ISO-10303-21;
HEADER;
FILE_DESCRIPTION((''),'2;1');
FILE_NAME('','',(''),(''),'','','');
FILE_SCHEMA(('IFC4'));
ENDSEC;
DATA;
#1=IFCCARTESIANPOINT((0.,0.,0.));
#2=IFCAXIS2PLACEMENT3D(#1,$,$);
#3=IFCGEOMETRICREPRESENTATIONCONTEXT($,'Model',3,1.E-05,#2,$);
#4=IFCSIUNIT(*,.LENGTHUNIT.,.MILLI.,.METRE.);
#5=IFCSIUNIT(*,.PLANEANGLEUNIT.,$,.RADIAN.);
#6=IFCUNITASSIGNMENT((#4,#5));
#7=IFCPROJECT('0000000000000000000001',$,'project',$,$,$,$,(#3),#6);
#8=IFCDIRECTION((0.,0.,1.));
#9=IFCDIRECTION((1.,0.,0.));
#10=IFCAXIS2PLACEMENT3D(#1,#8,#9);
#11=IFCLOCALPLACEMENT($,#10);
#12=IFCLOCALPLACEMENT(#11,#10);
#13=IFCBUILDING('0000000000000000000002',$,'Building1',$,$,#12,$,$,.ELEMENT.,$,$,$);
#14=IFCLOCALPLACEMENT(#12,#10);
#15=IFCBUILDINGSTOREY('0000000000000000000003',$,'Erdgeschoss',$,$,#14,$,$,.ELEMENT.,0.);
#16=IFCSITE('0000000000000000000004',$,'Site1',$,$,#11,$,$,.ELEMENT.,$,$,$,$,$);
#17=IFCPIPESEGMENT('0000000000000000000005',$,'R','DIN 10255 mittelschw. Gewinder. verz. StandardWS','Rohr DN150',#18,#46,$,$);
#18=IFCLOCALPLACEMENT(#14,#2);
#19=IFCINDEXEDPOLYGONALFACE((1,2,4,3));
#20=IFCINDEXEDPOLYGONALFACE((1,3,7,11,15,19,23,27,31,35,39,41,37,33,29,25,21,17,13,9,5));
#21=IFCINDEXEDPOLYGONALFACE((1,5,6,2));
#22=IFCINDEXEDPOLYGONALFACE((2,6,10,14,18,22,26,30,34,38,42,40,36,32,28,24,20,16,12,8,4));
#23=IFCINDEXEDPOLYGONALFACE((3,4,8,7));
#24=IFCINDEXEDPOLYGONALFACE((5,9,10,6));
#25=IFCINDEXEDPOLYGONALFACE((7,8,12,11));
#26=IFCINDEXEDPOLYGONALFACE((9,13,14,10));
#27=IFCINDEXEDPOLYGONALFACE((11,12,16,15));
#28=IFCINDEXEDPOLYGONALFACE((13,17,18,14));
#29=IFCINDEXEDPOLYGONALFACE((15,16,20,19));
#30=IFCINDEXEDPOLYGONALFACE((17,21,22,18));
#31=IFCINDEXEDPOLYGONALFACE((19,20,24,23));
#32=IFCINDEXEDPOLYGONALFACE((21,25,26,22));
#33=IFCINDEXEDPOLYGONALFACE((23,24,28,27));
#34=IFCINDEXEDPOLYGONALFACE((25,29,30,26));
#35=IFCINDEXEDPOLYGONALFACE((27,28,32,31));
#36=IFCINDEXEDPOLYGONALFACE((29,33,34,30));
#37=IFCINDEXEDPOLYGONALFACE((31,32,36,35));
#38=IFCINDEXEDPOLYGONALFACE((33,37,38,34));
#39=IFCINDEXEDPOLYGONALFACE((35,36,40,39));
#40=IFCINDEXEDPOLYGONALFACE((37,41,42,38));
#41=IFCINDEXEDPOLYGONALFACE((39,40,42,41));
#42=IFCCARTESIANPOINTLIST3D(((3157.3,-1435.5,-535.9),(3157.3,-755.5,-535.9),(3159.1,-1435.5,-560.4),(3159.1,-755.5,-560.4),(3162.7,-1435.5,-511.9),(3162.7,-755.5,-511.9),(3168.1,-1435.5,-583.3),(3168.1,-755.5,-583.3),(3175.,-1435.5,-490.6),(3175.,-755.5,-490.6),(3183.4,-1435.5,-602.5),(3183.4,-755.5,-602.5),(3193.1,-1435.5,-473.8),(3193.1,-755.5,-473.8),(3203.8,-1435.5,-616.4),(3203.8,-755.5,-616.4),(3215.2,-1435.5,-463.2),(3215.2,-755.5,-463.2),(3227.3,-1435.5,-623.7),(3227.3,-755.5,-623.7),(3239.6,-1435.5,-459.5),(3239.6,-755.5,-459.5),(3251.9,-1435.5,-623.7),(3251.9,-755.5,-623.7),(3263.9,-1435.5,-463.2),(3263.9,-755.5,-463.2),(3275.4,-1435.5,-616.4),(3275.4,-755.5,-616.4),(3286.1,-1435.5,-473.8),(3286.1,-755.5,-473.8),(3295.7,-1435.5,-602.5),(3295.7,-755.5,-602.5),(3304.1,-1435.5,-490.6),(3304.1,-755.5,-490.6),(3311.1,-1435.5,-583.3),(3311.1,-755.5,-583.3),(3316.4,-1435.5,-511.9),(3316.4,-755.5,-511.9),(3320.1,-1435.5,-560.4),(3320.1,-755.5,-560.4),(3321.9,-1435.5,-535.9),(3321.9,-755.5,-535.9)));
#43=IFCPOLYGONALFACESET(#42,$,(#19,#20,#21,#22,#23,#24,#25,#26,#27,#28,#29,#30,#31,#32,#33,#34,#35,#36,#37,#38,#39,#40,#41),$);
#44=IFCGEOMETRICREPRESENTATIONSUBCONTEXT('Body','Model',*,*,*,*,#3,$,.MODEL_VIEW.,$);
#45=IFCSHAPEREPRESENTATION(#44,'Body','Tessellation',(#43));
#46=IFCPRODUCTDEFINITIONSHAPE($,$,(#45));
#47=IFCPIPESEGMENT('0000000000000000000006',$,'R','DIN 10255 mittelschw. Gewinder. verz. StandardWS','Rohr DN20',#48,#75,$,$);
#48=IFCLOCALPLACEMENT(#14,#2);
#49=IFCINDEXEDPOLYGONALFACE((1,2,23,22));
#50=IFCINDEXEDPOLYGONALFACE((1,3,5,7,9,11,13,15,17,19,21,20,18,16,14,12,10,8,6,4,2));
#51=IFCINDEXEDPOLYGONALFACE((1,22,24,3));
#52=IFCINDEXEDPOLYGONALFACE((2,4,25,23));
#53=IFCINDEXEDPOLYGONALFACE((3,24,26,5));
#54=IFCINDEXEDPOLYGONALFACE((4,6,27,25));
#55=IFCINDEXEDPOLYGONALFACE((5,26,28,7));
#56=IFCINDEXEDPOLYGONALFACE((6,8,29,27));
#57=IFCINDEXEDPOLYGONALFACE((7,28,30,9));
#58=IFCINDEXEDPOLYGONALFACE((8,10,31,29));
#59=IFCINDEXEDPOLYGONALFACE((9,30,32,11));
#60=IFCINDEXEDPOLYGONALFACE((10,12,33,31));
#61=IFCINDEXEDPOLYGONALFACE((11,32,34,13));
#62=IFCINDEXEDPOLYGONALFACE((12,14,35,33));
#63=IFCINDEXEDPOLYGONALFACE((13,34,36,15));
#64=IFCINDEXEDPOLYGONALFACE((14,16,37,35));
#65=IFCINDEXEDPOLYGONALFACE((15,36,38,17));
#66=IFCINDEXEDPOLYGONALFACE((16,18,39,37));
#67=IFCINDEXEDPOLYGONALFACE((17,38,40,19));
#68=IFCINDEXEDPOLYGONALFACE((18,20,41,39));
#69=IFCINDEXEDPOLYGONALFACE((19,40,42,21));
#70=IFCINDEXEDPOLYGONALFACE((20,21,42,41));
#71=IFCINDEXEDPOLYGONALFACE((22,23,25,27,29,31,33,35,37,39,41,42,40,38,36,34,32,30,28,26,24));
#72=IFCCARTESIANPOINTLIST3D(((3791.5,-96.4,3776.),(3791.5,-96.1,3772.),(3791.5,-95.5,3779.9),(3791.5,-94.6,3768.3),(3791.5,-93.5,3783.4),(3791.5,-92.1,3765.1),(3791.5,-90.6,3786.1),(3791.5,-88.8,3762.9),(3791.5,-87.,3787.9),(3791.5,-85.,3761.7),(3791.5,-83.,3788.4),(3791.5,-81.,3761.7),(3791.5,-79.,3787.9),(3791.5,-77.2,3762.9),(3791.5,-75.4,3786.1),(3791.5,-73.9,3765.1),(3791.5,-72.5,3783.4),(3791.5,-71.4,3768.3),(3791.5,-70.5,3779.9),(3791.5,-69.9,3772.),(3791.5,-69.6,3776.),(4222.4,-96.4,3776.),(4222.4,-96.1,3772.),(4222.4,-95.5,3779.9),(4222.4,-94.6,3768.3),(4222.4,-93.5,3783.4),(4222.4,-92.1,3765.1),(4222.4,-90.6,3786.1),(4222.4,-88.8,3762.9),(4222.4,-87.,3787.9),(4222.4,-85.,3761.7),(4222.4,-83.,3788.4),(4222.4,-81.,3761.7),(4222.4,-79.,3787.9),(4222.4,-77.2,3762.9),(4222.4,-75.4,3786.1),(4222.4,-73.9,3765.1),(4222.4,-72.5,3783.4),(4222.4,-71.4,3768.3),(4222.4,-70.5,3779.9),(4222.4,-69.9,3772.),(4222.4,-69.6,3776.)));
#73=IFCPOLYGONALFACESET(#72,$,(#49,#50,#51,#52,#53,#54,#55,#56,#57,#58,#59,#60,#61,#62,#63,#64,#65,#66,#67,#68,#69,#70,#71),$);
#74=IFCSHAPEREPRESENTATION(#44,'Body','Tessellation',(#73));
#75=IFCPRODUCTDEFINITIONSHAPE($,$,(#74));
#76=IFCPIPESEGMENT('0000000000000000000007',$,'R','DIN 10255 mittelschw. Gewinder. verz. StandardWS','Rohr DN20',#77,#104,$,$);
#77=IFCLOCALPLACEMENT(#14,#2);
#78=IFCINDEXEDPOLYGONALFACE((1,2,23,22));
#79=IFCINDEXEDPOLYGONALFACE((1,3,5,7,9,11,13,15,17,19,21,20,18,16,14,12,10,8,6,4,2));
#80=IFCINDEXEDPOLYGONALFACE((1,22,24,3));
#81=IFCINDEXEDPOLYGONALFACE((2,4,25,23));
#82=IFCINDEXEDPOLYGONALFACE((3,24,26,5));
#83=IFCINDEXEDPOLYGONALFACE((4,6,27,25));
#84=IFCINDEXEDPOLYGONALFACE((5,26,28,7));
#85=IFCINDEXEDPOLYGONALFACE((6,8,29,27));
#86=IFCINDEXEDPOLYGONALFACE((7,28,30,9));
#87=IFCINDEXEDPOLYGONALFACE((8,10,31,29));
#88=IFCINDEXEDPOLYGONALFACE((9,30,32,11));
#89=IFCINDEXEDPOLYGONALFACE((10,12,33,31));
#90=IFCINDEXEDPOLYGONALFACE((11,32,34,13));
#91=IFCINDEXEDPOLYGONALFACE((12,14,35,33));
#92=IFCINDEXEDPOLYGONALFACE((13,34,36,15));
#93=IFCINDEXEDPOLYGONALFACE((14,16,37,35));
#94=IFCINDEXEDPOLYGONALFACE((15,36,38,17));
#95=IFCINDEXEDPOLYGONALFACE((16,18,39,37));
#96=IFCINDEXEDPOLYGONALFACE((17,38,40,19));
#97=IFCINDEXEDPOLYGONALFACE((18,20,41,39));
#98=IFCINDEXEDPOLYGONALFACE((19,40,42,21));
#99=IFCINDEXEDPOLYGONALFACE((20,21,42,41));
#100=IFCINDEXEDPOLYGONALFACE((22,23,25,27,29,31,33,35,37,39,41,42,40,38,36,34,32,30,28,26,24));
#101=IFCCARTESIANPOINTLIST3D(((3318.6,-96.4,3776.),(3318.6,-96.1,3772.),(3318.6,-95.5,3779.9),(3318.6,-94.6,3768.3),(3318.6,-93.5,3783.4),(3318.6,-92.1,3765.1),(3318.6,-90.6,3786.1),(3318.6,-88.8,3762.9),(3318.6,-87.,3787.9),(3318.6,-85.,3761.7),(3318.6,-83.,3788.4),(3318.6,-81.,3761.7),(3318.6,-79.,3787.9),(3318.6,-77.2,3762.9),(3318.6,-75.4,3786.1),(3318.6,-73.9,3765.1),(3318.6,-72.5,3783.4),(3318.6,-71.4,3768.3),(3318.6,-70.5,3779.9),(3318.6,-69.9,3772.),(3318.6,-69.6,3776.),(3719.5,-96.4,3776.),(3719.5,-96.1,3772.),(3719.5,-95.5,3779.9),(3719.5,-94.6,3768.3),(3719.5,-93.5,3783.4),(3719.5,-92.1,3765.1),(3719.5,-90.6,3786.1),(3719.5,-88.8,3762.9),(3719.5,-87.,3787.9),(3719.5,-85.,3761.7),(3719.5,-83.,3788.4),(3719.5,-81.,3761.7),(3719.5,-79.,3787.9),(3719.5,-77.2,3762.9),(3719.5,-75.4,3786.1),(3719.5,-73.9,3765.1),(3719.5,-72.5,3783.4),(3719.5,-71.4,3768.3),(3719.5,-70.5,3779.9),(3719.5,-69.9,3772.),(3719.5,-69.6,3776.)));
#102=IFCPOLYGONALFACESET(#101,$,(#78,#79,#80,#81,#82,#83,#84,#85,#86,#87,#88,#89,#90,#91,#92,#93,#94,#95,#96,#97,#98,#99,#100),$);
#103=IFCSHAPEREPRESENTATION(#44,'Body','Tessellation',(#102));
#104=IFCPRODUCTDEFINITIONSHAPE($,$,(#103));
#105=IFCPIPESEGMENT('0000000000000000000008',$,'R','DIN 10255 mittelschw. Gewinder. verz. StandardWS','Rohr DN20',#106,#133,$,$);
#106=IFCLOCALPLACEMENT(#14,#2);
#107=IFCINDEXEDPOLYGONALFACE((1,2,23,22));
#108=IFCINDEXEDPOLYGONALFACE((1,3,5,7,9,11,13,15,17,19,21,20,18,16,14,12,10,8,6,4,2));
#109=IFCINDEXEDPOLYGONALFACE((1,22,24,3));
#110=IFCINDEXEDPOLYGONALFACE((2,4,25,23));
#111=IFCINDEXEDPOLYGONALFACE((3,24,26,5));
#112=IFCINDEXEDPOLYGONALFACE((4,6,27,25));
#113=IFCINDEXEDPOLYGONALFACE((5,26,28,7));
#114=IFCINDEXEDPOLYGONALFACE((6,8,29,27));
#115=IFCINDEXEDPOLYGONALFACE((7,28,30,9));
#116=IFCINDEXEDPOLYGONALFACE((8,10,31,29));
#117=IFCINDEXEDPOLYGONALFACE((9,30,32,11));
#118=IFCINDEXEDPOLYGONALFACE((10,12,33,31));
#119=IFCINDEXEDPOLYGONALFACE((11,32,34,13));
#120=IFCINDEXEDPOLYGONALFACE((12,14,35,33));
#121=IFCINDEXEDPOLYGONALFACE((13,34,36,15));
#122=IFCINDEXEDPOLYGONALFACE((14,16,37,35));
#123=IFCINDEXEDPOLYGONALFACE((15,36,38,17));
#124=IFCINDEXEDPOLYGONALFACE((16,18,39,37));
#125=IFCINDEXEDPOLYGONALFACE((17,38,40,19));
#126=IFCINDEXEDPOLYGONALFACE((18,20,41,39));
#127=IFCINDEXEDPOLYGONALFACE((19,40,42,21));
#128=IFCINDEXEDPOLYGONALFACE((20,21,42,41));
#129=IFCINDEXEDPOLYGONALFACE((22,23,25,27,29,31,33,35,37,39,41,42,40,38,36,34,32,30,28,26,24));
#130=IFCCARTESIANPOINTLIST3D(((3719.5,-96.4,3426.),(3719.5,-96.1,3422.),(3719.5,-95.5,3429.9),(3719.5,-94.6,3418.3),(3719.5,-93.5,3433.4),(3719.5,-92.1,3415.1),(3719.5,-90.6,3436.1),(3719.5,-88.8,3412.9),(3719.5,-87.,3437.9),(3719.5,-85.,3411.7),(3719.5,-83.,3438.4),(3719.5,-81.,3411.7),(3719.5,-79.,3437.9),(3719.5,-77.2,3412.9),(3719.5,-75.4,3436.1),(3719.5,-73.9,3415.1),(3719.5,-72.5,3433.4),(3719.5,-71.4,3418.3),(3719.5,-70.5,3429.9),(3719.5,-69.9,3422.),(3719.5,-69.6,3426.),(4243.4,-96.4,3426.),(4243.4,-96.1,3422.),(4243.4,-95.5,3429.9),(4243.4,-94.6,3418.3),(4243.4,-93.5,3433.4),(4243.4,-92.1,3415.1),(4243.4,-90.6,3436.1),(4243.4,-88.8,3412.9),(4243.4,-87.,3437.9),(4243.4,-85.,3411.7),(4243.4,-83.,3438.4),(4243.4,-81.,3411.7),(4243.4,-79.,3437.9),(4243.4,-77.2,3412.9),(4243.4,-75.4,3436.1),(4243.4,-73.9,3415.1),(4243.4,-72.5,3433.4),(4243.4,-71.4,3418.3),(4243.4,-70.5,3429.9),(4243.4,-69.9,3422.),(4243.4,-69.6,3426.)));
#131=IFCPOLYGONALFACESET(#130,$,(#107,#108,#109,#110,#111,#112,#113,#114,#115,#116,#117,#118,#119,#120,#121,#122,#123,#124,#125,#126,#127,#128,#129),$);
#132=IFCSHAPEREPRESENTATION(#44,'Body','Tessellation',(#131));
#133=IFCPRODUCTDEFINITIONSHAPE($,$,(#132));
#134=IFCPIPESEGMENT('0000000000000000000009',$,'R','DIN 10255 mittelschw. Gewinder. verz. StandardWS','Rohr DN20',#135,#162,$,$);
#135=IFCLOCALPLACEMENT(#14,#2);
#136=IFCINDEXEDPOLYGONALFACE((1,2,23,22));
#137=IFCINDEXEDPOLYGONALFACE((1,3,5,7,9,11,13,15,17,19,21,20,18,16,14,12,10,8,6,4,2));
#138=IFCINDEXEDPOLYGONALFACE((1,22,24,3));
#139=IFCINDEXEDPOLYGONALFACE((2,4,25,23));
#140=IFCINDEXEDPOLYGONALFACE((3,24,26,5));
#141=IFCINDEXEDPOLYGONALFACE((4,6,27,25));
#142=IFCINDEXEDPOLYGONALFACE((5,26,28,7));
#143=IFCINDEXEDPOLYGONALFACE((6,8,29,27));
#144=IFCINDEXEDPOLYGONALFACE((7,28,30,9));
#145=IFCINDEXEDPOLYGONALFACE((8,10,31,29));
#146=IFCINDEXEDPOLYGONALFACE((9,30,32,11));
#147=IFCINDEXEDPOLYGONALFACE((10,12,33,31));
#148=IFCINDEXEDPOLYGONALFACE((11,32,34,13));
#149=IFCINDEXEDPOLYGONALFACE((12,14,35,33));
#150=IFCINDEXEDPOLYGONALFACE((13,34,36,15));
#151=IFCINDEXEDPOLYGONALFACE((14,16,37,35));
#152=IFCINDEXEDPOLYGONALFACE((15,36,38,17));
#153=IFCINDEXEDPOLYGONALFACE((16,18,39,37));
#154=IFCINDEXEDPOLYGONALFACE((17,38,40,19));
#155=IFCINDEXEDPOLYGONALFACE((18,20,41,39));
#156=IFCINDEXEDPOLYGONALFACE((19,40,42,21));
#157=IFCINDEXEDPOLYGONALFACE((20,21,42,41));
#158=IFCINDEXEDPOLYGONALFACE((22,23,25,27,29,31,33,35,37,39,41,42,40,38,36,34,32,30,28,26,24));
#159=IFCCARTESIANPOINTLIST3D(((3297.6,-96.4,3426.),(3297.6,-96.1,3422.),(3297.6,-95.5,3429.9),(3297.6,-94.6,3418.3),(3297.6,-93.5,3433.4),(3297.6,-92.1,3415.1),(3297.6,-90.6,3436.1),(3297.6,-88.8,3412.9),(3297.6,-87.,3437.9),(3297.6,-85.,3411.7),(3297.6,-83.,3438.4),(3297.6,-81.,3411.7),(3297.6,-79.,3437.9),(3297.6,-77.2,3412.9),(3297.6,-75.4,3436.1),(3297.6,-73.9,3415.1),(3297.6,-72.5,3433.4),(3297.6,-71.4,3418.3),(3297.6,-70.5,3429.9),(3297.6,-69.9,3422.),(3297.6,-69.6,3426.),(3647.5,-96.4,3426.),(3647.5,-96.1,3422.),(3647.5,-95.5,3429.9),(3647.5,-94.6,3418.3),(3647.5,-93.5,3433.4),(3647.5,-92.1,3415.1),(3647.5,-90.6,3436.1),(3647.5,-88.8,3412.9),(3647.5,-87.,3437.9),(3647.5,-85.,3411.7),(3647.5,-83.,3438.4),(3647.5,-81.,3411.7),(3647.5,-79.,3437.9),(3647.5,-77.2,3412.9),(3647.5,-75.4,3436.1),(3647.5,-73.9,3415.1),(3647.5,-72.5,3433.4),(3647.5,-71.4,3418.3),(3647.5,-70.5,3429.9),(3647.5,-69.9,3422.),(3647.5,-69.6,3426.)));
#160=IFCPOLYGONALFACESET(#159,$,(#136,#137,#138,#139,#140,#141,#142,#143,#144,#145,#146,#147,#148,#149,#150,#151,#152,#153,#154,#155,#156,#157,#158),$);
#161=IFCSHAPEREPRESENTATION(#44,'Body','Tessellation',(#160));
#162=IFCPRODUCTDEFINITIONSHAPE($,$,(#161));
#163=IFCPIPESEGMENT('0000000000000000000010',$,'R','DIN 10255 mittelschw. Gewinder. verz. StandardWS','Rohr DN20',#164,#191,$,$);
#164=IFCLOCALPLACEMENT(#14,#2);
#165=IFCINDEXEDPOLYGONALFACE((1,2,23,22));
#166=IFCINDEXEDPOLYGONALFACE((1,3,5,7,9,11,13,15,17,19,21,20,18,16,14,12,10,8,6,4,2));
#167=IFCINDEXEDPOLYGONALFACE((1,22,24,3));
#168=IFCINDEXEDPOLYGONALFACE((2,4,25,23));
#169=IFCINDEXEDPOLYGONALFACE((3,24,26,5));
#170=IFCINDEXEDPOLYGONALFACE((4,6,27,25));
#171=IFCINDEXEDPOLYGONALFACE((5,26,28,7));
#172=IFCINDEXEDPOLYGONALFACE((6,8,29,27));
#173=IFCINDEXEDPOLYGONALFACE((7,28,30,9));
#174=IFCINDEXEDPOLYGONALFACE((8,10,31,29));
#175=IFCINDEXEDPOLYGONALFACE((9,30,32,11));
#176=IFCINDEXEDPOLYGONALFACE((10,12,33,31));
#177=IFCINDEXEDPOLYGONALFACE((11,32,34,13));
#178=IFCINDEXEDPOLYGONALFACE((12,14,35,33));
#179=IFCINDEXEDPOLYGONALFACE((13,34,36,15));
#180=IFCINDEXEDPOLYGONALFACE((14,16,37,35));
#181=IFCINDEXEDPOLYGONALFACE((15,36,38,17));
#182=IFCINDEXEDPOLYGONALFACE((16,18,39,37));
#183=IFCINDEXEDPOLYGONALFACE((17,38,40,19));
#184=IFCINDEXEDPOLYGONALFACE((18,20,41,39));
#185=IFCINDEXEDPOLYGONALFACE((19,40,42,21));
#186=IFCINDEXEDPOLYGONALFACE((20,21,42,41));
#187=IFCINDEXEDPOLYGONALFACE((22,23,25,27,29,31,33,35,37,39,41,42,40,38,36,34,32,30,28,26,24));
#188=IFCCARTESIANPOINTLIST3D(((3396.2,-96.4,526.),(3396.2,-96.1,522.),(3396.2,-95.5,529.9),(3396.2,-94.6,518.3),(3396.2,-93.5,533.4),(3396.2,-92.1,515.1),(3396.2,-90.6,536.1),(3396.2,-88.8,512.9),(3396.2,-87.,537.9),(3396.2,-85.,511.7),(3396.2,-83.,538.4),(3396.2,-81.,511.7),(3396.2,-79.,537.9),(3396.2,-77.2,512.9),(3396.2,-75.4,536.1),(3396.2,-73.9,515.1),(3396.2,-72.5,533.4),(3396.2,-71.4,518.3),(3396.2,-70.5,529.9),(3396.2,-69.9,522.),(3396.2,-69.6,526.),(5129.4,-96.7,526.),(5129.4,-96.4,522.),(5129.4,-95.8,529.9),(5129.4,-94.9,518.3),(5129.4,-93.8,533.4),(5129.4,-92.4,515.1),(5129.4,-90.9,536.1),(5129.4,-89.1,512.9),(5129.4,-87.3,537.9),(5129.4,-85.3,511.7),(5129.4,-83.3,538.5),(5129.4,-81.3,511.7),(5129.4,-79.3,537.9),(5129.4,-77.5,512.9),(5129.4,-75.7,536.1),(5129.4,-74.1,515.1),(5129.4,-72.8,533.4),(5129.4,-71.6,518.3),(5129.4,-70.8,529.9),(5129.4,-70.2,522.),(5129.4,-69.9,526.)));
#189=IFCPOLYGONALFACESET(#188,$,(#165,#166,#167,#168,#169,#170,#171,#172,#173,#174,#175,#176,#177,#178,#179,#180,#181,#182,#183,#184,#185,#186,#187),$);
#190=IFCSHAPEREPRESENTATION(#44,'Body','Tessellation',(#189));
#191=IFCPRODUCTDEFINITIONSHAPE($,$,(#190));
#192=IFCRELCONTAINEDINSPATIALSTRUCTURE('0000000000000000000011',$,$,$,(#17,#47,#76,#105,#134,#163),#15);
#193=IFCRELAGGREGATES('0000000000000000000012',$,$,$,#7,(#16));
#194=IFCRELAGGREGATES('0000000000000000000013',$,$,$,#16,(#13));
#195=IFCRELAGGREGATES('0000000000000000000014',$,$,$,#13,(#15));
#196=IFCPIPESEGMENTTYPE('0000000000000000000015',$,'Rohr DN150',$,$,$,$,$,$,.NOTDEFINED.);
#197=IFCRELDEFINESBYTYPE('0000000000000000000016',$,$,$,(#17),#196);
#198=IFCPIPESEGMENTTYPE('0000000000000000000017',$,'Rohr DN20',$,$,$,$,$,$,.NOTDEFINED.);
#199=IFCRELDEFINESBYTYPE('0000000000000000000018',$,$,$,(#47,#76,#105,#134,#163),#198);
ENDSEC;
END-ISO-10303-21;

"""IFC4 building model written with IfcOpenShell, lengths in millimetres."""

from ifc_helpers import new_model, si_unit, frame, origin, origin_with_axes, origin_2d_with_axis, place, context, subcontext, project, spatial, circle, extrude, type_object, element, save


model = new_model("IFC4")

# Units and contexts
model_context = context("Model", 3, precision=1e-05, world=origin())
body_context = subcontext(model_context, "Body", "Model", "MODEL_VIEW")
ifc_project = project(units=[si_unit("LENGTHUNIT", "METRE", prefix="MILLI"), si_unit("PLANEANGLEUNIT", "RADIAN")], contexts=[model_context])

# Site, building, storey
site_placement = place(None, origin_with_axes())
site = spatial("IfcSite", under=ifc_project, at=site_placement, Name="Site1", CompositionType="ELEMENT")
building_placement = place(site_placement, origin_with_axes())
building = spatial("IfcBuilding", under=site, at=building_placement, Name="Building1", CompositionType="ELEMENT")
storey_placement = place(building_placement, origin_with_axes())
storey = spatial("IfcBuildingStorey", under=building, at=storey_placement, Name="Erdgeschoss", CompositionType="ELEMENT", Elevation=0.0)

# Pipe segments
pipe_segment_type_1 = type_object("IfcPipeSegmentType", Name="Rohr DN150", PredefinedType="NOTDEFINED")
pipe_segment_1_placement = place(storey_placement, frame((3239.7, -1095.5, -542.0), z_axis=(0.0, 0.0, 1.0), x_axis=(1.0, 0.0, 0.0)))
element("IfcPipeSegment", 1, at=pipe_segment_1_placement, inside=storey, type_object=pipe_segment_type_1, Name="R", Description="DIN 10255 mittelschw. Gewinder. verz. StandardWS", ObjectType="Rohr DN150", context=body_context, shape_type="SolidModel", body=[
    extrude(circle(Radius=82.5, at=origin_2d_with_axis()), frame((-0.2, 340.0, 0.0), z_axis=(0.0, -1.0, 0.0), x_axis=(0.0, 0.0, 1.0)), (0.0, 0.0, 1.0), 680.0),
])
pipe_segment_type_2 = type_object("IfcPipeSegmentType", Name="Rohr DN20", PredefinedType="NOTDEFINED")
pipe_segment_2_placement = place(storey_placement, frame((4006.9, -83.2, 3775.0), z_axis=(0.0, 0.0, 1.0), x_axis=(1.0, 0.0, 0.0)))
element("IfcPipeSegment", 2, at=pipe_segment_2_placement, inside=storey, type_object=pipe_segment_type_2, Name="R", Description="DIN 10255 mittelschw. Gewinder. verz. StandardWS", ObjectType="Rohr DN20", context=body_context, shape_type="SolidModel", body=[
    extrude(circle(Radius=13.4, at=origin_2d_with_axis()), frame((215.5, 0.2, 0.0), z_axis=(-1.0, 0.0, 0.0), x_axis=(0.0, 0.0, 1.0)), (0.0, 0.0, 1.0), 430.9),
])
pipe_segment_3_placement = place(storey_placement, frame((3519.0, -83.2, 3775.0), z_axis=(0.0, 0.0, 1.0), x_axis=(1.0, 0.0, 0.0)))
element("IfcPipeSegment", 3, at=pipe_segment_3_placement, inside=storey, type_object=pipe_segment_type_2, Name="R", Description="DIN 10255 mittelschw. Gewinder. verz. StandardWS", ObjectType="Rohr DN20", context=body_context, shape_type="SolidModel", body=[
    extrude(circle(Radius=13.4, at=origin_2d_with_axis()), frame((200.5, 0.2, 0.0), z_axis=(-1.0, 0.0, 0.0), x_axis=(0.0, 0.0, 1.0)), (0.0, 0.0, 1.0), 400.9),
])
pipe_segment_4_placement = place(storey_placement, frame((3981.4, -83.2, 3425.0), z_axis=(0.0, 0.0, 1.0), x_axis=(1.0, 0.0, 0.0)))
element("IfcPipeSegment", 4, at=pipe_segment_4_placement, inside=storey, type_object=pipe_segment_type_2, Name="R", Description="DIN 10255 mittelschw. Gewinder. verz. StandardWS", ObjectType="Rohr DN20", context=body_context, shape_type="SolidModel", body=[
    extrude(circle(Radius=13.4, at=origin_2d_with_axis()), frame((261.9, 0.2, 0.0), z_axis=(-1.0, 0.0, 0.0), x_axis=(0.0, 0.0, 1.0)), (0.0, 0.0, 1.0), 523.9),
])
pipe_segment_5_placement = place(storey_placement, frame((3472.5, -83.2, 3425.0), z_axis=(0.0, 0.0, 1.0), x_axis=(1.0, 0.0, 0.0)))
element("IfcPipeSegment", 5, at=pipe_segment_5_placement, inside=storey, type_object=pipe_segment_type_2, Name="R", Description="DIN 10255 mittelschw. Gewinder. verz. StandardWS", ObjectType="Rohr DN20", context=body_context, shape_type="SolidModel", body=[
    extrude(circle(Radius=13.4, at=origin_2d_with_axis()), frame((175.0, 0.2, 0.0), z_axis=(-1.0, 0.0, 0.0), x_axis=(0.0, 0.0, 1.0)), (0.0, 0.0, 1.0), 349.9),
])
pipe_segment_6_placement = place(storey_placement, frame((4262.8, -83.3, 525.0), z_axis=(0.0, 0.0, 1.0), x_axis=(1.0, 0.0, 0.0)))
element("IfcPipeSegment", 6, at=pipe_segment_6_placement, inside=storey, type_object=pipe_segment_type_2, Name="R", Description="DIN 10255 mittelschw. Gewinder. verz. StandardWS", ObjectType="Rohr DN20", context=body_context, shape_type="SolidModel", body=[
    extrude(circle(Radius=13.4, at=origin_2d_with_axis()), frame((866.6, 0.0, 0.0), z_axis=(-1.0, 0.000169, -0.000005), x_axis=(0.0, 0.0, 1.0)), (0.0, 0.0, 1.0), 1733.1),
])

save(model, "model.ifc")
